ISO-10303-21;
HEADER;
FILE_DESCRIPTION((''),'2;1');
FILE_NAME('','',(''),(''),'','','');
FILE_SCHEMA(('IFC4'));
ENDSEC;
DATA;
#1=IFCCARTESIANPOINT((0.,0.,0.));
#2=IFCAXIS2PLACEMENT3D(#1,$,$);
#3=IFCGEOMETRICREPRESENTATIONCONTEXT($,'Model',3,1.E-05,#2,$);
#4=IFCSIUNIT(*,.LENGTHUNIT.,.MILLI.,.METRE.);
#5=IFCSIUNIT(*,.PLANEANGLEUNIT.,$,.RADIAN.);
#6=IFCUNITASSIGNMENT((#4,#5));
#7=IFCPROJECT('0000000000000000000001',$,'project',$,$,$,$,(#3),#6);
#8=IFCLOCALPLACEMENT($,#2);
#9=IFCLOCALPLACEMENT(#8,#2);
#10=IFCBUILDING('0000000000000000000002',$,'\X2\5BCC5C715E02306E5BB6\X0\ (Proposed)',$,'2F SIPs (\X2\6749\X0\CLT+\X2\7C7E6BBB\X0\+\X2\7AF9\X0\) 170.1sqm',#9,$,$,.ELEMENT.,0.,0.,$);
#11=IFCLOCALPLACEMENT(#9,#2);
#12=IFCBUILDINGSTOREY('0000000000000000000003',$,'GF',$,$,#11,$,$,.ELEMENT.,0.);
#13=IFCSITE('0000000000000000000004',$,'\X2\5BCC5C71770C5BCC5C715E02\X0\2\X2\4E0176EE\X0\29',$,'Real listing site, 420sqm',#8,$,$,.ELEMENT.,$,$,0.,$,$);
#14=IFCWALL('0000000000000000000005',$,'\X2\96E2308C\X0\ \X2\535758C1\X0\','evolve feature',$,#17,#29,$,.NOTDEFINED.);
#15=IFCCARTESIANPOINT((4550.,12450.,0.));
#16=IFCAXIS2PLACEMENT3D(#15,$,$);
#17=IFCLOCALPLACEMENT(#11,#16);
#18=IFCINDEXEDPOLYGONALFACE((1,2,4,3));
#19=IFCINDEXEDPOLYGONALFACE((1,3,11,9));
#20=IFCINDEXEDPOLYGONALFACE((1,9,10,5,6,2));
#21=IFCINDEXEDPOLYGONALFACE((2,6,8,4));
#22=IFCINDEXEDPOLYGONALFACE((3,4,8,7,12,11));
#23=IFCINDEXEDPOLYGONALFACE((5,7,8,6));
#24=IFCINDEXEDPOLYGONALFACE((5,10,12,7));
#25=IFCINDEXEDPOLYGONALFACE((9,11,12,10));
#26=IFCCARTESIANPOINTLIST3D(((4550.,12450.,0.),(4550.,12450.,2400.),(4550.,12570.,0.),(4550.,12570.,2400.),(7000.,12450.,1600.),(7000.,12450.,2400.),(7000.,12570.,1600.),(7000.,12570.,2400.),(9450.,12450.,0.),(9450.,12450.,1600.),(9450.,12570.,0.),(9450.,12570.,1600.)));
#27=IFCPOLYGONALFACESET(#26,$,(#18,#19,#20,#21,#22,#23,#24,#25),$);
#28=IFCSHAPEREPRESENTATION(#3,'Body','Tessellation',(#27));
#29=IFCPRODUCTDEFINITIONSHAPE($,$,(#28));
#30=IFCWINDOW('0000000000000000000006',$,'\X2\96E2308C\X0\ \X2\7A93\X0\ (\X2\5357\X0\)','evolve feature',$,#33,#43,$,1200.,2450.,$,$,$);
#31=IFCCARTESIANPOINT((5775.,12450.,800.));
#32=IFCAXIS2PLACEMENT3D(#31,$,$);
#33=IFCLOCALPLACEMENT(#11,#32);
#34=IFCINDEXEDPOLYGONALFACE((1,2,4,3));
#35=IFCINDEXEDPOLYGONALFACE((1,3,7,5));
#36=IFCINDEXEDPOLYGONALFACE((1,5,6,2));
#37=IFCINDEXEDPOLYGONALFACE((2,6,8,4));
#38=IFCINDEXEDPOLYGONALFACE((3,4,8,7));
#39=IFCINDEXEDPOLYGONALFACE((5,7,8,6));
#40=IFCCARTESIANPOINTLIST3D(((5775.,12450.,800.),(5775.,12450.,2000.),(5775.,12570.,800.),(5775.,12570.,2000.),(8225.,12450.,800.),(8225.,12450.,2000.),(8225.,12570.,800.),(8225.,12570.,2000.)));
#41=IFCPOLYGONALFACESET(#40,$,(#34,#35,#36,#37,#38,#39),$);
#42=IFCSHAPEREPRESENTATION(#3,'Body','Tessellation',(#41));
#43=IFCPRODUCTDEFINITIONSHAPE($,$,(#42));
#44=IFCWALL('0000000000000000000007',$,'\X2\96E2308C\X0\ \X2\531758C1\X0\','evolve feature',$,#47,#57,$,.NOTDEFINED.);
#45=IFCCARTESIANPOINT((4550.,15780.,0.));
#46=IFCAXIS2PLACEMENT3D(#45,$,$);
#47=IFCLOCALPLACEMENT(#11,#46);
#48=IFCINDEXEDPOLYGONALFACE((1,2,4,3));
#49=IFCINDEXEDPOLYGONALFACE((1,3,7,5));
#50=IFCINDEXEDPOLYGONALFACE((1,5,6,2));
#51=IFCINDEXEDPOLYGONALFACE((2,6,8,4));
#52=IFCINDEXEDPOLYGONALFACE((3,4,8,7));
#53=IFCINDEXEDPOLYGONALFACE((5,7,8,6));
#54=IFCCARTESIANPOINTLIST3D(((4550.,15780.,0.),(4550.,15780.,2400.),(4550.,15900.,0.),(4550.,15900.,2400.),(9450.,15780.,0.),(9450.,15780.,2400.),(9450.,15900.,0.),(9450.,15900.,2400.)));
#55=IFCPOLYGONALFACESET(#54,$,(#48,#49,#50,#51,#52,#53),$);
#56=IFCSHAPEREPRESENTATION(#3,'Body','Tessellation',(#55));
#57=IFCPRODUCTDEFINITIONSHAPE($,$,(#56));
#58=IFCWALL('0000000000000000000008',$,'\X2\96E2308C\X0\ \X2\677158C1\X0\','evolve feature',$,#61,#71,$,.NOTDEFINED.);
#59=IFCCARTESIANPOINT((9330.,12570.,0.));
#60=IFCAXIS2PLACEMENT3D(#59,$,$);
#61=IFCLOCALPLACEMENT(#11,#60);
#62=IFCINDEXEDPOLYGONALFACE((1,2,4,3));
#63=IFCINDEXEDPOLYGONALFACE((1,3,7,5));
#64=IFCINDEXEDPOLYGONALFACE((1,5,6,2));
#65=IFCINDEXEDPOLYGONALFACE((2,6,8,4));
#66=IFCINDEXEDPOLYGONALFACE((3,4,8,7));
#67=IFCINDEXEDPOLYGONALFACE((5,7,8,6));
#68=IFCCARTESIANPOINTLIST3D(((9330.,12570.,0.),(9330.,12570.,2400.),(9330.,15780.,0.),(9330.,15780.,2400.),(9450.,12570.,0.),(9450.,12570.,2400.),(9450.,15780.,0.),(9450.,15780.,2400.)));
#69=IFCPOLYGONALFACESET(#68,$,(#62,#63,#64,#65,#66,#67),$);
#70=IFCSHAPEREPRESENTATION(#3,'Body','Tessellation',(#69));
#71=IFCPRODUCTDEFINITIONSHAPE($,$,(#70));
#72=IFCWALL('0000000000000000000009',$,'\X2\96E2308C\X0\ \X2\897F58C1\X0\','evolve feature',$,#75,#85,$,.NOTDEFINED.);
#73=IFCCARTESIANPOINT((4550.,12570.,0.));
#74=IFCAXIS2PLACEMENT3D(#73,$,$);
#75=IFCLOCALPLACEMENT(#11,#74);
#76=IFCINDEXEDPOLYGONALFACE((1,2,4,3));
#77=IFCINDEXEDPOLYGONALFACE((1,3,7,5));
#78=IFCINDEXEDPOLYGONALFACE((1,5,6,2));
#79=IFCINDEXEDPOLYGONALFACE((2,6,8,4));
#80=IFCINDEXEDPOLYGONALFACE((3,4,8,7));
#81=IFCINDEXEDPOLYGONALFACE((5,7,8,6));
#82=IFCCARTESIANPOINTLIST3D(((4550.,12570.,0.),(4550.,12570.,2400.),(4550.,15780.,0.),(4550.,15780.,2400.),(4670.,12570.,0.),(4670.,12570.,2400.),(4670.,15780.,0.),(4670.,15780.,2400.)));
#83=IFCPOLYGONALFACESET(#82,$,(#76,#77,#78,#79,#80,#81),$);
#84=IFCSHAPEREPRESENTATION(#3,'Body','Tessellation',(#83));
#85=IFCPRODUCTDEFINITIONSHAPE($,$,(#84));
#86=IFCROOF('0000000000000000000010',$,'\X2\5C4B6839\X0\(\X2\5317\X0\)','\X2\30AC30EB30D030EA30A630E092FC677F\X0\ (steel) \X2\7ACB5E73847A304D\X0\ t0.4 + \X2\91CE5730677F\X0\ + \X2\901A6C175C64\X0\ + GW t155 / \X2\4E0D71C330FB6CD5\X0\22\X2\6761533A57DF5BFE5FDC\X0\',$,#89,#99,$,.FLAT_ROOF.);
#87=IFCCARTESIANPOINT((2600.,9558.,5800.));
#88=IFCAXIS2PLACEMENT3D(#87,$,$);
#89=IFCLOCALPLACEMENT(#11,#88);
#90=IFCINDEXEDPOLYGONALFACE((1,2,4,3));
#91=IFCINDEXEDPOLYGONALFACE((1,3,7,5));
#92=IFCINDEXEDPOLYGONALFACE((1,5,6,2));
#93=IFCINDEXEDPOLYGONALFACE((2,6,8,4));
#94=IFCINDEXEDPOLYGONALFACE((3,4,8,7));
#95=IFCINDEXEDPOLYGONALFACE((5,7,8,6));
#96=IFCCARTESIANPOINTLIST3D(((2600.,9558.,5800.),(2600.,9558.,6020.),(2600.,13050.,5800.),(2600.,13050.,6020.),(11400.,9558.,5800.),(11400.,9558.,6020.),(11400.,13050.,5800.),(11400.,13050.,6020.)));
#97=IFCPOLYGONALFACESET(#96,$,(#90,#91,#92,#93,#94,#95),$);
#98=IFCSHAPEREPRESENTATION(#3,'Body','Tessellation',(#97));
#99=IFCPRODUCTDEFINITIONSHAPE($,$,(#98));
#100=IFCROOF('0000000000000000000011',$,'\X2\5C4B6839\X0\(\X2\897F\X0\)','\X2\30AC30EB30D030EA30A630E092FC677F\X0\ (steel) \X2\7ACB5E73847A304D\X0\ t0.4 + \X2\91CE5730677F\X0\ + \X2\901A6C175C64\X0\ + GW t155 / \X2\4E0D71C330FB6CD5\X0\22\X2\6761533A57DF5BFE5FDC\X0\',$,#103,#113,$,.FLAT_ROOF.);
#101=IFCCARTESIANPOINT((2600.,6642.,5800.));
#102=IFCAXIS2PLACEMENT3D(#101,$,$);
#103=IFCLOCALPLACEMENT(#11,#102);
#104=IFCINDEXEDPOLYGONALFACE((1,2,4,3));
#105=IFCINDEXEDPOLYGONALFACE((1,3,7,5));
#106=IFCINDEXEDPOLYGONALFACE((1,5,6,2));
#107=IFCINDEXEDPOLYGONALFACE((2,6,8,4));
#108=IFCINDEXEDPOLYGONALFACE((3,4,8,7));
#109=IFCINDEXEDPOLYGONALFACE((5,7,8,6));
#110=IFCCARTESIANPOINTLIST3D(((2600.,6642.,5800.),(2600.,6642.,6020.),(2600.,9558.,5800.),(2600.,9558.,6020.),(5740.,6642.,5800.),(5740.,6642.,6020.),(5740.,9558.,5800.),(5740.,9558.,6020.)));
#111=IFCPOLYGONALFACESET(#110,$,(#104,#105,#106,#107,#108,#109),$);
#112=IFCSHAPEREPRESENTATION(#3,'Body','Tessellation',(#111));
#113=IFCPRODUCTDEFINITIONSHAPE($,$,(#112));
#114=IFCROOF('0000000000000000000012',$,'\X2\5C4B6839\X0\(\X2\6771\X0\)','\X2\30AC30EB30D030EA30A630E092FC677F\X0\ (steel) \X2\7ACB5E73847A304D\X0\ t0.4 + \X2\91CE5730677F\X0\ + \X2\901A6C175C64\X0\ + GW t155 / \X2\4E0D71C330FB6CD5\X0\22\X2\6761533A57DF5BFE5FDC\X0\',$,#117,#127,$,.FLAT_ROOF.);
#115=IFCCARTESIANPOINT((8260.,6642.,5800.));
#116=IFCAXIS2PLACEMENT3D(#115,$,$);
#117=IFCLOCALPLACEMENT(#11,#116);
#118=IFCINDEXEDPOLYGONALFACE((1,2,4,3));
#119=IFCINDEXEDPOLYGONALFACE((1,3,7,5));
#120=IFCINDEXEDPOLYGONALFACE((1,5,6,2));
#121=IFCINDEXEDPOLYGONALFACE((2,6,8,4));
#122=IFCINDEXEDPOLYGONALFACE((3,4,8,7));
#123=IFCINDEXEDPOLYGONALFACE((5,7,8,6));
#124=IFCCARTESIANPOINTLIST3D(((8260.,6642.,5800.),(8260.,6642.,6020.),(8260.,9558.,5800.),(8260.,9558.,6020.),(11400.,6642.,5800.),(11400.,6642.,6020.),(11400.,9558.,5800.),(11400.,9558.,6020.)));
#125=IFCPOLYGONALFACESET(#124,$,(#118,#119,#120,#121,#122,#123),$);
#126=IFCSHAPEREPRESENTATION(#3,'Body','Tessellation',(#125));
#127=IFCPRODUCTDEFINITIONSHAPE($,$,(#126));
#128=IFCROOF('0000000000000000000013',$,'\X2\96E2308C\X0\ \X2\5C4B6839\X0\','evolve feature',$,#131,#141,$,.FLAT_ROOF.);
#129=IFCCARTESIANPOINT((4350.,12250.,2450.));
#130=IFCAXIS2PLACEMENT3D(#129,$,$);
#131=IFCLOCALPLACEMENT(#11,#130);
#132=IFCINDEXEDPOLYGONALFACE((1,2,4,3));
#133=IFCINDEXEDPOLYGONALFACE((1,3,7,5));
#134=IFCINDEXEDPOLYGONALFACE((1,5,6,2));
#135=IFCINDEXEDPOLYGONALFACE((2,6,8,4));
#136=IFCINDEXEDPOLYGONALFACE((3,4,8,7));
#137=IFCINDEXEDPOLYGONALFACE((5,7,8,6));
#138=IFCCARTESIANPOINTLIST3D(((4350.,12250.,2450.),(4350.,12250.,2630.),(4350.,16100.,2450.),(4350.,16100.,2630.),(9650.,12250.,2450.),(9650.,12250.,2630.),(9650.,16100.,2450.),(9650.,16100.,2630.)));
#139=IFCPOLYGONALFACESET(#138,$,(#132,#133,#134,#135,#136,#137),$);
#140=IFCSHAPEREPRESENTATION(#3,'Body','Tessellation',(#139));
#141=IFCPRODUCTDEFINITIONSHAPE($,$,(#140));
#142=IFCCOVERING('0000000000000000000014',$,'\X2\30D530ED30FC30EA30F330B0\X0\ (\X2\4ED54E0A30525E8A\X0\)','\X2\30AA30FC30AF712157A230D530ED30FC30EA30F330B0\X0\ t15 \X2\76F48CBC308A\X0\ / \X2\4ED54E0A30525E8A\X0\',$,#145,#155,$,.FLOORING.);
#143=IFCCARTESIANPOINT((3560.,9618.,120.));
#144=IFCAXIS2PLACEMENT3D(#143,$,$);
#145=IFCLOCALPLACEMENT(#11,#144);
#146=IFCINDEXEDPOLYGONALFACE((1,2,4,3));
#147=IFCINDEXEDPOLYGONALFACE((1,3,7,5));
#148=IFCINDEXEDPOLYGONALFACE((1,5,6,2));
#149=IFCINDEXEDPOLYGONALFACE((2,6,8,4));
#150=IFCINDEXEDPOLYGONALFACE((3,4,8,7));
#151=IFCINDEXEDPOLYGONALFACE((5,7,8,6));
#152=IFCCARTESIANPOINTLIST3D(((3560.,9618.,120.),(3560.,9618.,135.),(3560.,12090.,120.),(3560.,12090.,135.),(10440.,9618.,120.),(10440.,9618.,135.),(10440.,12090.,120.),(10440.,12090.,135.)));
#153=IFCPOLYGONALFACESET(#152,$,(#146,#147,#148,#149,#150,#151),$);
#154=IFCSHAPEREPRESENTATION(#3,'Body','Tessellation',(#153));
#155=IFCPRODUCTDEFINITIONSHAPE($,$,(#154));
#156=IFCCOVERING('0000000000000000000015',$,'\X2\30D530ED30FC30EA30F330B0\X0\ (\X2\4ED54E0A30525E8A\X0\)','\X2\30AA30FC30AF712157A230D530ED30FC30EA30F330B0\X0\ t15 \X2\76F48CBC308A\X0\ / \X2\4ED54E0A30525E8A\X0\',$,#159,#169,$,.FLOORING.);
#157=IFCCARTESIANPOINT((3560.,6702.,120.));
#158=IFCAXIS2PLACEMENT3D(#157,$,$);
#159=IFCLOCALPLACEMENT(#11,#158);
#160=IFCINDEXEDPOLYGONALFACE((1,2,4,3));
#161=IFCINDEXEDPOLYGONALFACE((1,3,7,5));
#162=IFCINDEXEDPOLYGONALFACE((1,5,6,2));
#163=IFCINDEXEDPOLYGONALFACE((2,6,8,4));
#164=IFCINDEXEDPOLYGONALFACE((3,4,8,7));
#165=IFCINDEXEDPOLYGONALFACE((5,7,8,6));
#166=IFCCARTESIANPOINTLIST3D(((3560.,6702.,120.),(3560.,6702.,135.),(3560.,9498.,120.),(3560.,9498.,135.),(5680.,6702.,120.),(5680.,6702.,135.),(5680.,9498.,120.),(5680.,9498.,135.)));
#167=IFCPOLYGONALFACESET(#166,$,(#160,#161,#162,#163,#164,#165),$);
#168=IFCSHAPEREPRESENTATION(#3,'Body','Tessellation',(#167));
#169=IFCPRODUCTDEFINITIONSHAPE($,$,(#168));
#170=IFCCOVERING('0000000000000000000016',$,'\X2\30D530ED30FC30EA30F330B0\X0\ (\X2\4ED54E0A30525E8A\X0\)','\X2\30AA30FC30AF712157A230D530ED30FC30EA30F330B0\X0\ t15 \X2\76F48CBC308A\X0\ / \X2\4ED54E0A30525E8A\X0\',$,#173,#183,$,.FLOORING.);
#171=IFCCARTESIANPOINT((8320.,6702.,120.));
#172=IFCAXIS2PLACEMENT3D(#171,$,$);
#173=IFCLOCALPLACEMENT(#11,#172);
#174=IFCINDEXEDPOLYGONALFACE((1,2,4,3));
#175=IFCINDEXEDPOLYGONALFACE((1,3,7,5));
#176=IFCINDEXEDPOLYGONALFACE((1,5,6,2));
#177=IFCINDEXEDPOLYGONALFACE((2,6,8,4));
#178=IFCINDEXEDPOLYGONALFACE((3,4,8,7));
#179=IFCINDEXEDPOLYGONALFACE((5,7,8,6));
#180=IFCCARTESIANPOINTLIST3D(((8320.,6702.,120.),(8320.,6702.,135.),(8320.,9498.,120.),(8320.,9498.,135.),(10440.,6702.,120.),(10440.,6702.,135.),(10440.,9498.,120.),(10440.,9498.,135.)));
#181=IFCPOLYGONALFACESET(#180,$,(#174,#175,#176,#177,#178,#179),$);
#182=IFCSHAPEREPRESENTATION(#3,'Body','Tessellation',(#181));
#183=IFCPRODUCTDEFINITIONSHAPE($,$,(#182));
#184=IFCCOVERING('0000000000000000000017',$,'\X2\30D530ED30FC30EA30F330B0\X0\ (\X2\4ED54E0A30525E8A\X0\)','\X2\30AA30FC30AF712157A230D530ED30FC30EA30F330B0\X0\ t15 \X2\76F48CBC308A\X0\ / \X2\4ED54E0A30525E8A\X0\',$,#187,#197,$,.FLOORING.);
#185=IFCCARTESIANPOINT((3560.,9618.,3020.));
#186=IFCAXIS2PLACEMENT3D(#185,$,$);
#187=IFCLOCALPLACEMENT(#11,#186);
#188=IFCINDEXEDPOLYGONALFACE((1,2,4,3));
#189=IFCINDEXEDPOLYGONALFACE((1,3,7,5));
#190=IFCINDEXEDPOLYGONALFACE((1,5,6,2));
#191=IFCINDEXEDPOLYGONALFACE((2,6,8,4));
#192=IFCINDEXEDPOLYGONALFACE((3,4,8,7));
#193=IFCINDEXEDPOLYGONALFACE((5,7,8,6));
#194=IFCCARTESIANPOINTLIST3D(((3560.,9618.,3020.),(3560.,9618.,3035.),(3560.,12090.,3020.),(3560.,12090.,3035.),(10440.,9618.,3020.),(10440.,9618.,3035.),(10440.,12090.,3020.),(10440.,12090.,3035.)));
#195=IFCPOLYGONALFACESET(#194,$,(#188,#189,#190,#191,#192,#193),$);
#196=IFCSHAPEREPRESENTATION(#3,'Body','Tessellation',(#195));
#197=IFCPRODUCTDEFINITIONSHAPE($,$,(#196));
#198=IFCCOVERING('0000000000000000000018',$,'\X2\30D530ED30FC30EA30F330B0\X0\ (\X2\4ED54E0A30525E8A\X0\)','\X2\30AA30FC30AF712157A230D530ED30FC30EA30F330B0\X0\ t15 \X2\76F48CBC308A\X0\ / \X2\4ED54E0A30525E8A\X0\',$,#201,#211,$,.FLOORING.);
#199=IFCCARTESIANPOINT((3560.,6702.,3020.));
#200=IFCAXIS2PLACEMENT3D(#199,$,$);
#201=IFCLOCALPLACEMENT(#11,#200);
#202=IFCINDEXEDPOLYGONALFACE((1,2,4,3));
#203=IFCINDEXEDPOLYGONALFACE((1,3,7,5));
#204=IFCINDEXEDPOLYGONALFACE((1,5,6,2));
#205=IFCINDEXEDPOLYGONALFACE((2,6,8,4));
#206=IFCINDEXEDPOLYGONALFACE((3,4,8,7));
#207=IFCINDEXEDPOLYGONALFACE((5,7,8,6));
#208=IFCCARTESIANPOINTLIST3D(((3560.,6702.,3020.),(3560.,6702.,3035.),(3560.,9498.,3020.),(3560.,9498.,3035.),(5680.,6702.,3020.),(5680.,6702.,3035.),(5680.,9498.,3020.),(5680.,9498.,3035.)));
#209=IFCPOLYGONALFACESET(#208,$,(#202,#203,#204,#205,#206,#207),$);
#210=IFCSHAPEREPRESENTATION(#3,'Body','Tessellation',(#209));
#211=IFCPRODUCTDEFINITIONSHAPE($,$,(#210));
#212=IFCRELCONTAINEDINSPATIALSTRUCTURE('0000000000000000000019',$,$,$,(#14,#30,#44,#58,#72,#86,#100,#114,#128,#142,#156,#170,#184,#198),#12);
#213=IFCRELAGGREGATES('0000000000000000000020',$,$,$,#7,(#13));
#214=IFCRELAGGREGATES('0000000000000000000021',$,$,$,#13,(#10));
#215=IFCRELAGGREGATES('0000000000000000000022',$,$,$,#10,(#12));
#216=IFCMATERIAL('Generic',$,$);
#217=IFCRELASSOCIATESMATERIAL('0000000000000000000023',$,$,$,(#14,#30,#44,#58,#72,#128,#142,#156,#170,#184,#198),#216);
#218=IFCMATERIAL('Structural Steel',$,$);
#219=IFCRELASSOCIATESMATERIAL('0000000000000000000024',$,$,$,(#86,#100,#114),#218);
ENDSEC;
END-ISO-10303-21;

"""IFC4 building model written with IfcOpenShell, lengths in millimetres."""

from ifc_helpers import new_model, si_unit, frame, frame_2d, origin, place, context, project, spatial, rectangle, extrude, material, element, fill, save


model = new_model("IFC4")

# Units and contexts
model_context = context("Model", 3, precision=1e-05, world=origin())
ifc_project = project(units=[si_unit("LENGTHUNIT", "METRE", prefix="MILLI"), si_unit("PLANEANGLEUNIT", "RADIAN")], contexts=[model_context])

# Site, building, storey
site_placement = place(None, origin())
site = spatial("IfcSite", under=ifc_project, at=site_placement, Name="富山県富山市2丁目29", ObjectType="Real listing site, 420sqm", CompositionType="ELEMENT", RefElevation=0.0)
building_placement = place(site_placement, origin())
building = spatial("IfcBuilding", under=site, at=building_placement, Name="富山市の家 (Proposed)", ObjectType="2F SIPs (杉CLT+籾殻+竹) 170.1sqm", CompositionType="ELEMENT", ElevationOfRefHeight=0.0, ElevationOfTerrain=0.0)
storey_placement = place(building_placement, origin())
storey = spatial("IfcBuildingStorey", under=building, at=storey_placement, Name="GF", CompositionType="ELEMENT", Elevation=0.0)

# Shared definitions
ifc_material_1 = material(Name="Generic")

# Wall, opening, window
wall_1_placement = place(storey_placement, frame((4550.0, 12450.0, 0.0)))
wall_1 = element("IfcWall", 1, at=wall_1_placement, inside=storey, material=ifc_material_1, Name="離れ 南壁", Description="evolve feature", PredefinedType="NOTDEFINED", context=model_context, shape_type="SweptSolid", body=[
    extrude(rectangle(XDim=4900.0, YDim=120.0, at=frame_2d((2450.0, 60.0))), frame((4550.0, 12450.0, 0.0)), (0.0, 0.0, 1.0), 2400.0),
])
opening_1_placement = place(storey_placement, frame((5775.0, 12450.0, 800.0)))
opening_1 = element("IfcOpeningElement", 2, at=opening_1_placement, cuts=wall_1, PredefinedType="NOTDEFINED", context=model_context, shape_type="SweptSolid", body=[
    extrude(rectangle(XDim=2450.0, YDim=120.0, at=frame_2d((1225.0, 60.0))), frame((5775.0, 12450.0, 800.0)), (0.0, 0.0, 1.0), 1200.0),
])
window_1_placement = place(storey_placement, frame((5775.0, 12450.0, 800.0)))
window_1 = element("IfcWindow", 3, at=window_1_placement, inside=storey, material=ifc_material_1, Name="離れ 窓 (南)", Description="evolve feature", OverallHeight=1200.0, OverallWidth=2450.0, context=model_context, shape_type="SweptSolid", body=[
    extrude(rectangle(XDim=2450.0, YDim=120.0, at=frame_2d((1225.0, 60.0))), frame((5775.0, 12450.0, 800.0)), (0.0, 0.0, 1.0), 1200.0),
])
fill(opening_1, window_1)

# Walls
wall_2_placement = place(storey_placement, frame((4550.0, 15780.0, 0.0)))
element("IfcWall", 4, at=wall_2_placement, inside=storey, material=ifc_material_1, Name="離れ 北壁", Description="evolve feature", PredefinedType="NOTDEFINED", context=model_context, shape_type="SweptSolid", body=[
    extrude(rectangle(XDim=4900.0, YDim=120.0, at=frame_2d((2450.0, 60.0))), frame((4550.0, 15780.0, 0.0)), (0.0, 0.0, 1.0), 2400.0),
])
wall_3_placement = place(storey_placement, frame((9330.0, 12570.0, 0.0)))
element("IfcWall", 5, at=wall_3_placement, inside=storey, material=ifc_material_1, Name="離れ 東壁", Description="evolve feature", PredefinedType="NOTDEFINED", context=model_context, shape_type="SweptSolid", body=[
    extrude(rectangle(XDim=120.0, YDim=3210.0, at=frame_2d((60.0, 1605.0))), frame((9330.0, 12570.0, 0.0)), (0.0, 0.0, 1.0), 2400.0),
])
wall_4_placement = place(storey_placement, frame((4550.0, 12570.0, 0.0)))
element("IfcWall", 6, at=wall_4_placement, inside=storey, material=ifc_material_1, Name="離れ 西壁", Description="evolve feature", PredefinedType="NOTDEFINED", context=model_context, shape_type="SweptSolid", body=[
    extrude(rectangle(XDim=120.0, YDim=3210.0, at=frame_2d((60.0, 1605.0))), frame((4550.0, 12570.0, 0.0)), (0.0, 0.0, 1.0), 2400.0),
])

# Roofs
ifc_material_2 = material(Name="Structural Steel")
for number, where, name in (
    (7, (2600.0, 9558.0, 5800.0), "屋根(北)"),
):
    element("IfcRoof", number, at=place(storey_placement, frame(where)), inside=storey, material=ifc_material_2, Name=name, Description="ガルバリウム鋼板 (steel) 立平葺き t0.4 + 野地板 + 通気層 + GW t155 / 不燃・法22条区域対応", PredefinedType="FLAT_ROOF", context=model_context, shape_type="SweptSolid", body=[
        extrude(rectangle(XDim=8800.0, YDim=3492.0, at=frame_2d((4400.0, 1746.0))), frame((2600.0, 9558.0, 5800.0)), (0.0, 0.0, 1.0), 220.0),
    ])
roof_1_placement = place(storey_placement, frame((2600.0, 6642.0, 5800.0)))
element("IfcRoof", 8, at=roof_1_placement, inside=storey, material=ifc_material_2, Name="屋根(西)", Description="ガルバリウム鋼板 (steel) 立平葺き t0.4 + 野地板 + 通気層 + GW t155 / 不燃・法22条区域対応", PredefinedType="FLAT_ROOF", context=model_context, shape_type="SweptSolid", body=[
    extrude(rectangle(XDim=3140.0, YDim=2916.0, at=frame_2d((1570.0, 1458.0))), frame((2600.0, 6642.0, 5800.0)), (0.0, 0.0, 1.0), 220.0),
])
roof_2_placement = place(storey_placement, frame((8260.0, 6642.0, 5800.0)))
element("IfcRoof", 9, at=roof_2_placement, inside=storey, material=ifc_material_2, Name="屋根(東)", Description="ガルバリウム鋼板 (steel) 立平葺き t0.4 + 野地板 + 通気層 + GW t155 / 不燃・法22条区域対応", PredefinedType="FLAT_ROOF", context=model_context, shape_type="SweptSolid", body=[
    extrude(rectangle(XDim=3140.0, YDim=2916.0, at=frame_2d((1570.0, 1458.0))), frame((8260.0, 6642.0, 5800.0)), (0.0, 0.0, 1.0), 220.0),
])
roof_3_placement = place(storey_placement, frame((4350.0, 12250.0, 2450.0)))
element("IfcRoof", 10, at=roof_3_placement, inside=storey, material=ifc_material_1, Name="離れ 屋根", Description="evolve feature", PredefinedType="FLAT_ROOF", context=model_context, shape_type="SweptSolid", body=[
    extrude(rectangle(XDim=5300.0, YDim=3850.0, at=frame_2d((2650.0, 1925.0))), frame((4350.0, 12250.0, 2450.0)), (0.0, 0.0, 1.0), 180.0),
])

# Coverings
covering_1_placement = place(storey_placement, frame((3560.0, 9618.0, 120.0)))
element("IfcCovering", 11, at=covering_1_placement, inside=storey, material=ifc_material_1, Name="フローリング (仕上げ床)", Description="オーク無垢フローリング t15 直貼り / 仕上げ床", PredefinedType="FLOORING", context=model_context, shape_type="SweptSolid", body=[
    extrude(rectangle(XDim=6880.0, YDim=2472.0, at=frame_2d((3440.0, 1236.0))), frame((3560.0, 9618.0, 120.0)), (0.0, 0.0, 1.0), 15.0),
])
covering_2_placement = place(storey_placement, frame((3560.0, 6702.0, 120.0)))
element("IfcCovering", 12, at=covering_2_placement, inside=storey, material=ifc_material_1, Name="フローリング (仕上げ床)", Description="オーク無垢フローリング t15 直貼り / 仕上げ床", PredefinedType="FLOORING", context=model_context, shape_type="SweptSolid", body=[
    extrude(rectangle(XDim=2120.0, YDim=2796.0, at=frame_2d((1060.0, 1398.0))), frame((3560.0, 6702.0, 120.0)), (0.0, 0.0, 1.0), 15.0),
])
covering_3_placement = place(storey_placement, frame((8320.0, 6702.0, 120.0)))
element("IfcCovering", 13, at=covering_3_placement, inside=storey, material=ifc_material_1, Name="フローリング (仕上げ床)", Description="オーク無垢フローリング t15 直貼り / 仕上げ床", PredefinedType="FLOORING", context=model_context, shape_type="SweptSolid", body=[
    extrude(rectangle(XDim=2120.0, YDim=2796.0, at=frame_2d((1060.0, 1398.0))), frame((8320.0, 6702.0, 120.0)), (0.0, 0.0, 1.0), 15.0),
])
covering_4_placement = place(storey_placement, frame((3560.0, 9618.0, 3020.0)))
element("IfcCovering", 14, at=covering_4_placement, inside=storey, material=ifc_material_1, Name="フローリング (仕上げ床)", Description="オーク無垢フローリング t15 直貼り / 仕上げ床", PredefinedType="FLOORING", context=model_context, shape_type="SweptSolid", body=[
    extrude(rectangle(XDim=6880.0, YDim=2472.0, at=frame_2d((3440.0, 1236.0))), frame((3560.0, 9618.0, 3020.0)), (0.0, 0.0, 1.0), 15.0),
])
covering_5_placement = place(storey_placement, frame((3560.0, 6702.0, 3020.0)))
element("IfcCovering", 15, at=covering_5_placement, inside=storey, material=ifc_material_1, Name="フローリング (仕上げ床)", Description="オーク無垢フローリング t15 直貼り / 仕上げ床", PredefinedType="FLOORING", context=model_context, shape_type="SweptSolid", body=[
    extrude(rectangle(XDim=2120.0, YDim=2796.0, at=frame_2d((1060.0, 1398.0))), frame((3560.0, 6702.0, 3020.0)), (0.0, 0.0, 1.0), 15.0),
])

save(model, "model.ifc")
